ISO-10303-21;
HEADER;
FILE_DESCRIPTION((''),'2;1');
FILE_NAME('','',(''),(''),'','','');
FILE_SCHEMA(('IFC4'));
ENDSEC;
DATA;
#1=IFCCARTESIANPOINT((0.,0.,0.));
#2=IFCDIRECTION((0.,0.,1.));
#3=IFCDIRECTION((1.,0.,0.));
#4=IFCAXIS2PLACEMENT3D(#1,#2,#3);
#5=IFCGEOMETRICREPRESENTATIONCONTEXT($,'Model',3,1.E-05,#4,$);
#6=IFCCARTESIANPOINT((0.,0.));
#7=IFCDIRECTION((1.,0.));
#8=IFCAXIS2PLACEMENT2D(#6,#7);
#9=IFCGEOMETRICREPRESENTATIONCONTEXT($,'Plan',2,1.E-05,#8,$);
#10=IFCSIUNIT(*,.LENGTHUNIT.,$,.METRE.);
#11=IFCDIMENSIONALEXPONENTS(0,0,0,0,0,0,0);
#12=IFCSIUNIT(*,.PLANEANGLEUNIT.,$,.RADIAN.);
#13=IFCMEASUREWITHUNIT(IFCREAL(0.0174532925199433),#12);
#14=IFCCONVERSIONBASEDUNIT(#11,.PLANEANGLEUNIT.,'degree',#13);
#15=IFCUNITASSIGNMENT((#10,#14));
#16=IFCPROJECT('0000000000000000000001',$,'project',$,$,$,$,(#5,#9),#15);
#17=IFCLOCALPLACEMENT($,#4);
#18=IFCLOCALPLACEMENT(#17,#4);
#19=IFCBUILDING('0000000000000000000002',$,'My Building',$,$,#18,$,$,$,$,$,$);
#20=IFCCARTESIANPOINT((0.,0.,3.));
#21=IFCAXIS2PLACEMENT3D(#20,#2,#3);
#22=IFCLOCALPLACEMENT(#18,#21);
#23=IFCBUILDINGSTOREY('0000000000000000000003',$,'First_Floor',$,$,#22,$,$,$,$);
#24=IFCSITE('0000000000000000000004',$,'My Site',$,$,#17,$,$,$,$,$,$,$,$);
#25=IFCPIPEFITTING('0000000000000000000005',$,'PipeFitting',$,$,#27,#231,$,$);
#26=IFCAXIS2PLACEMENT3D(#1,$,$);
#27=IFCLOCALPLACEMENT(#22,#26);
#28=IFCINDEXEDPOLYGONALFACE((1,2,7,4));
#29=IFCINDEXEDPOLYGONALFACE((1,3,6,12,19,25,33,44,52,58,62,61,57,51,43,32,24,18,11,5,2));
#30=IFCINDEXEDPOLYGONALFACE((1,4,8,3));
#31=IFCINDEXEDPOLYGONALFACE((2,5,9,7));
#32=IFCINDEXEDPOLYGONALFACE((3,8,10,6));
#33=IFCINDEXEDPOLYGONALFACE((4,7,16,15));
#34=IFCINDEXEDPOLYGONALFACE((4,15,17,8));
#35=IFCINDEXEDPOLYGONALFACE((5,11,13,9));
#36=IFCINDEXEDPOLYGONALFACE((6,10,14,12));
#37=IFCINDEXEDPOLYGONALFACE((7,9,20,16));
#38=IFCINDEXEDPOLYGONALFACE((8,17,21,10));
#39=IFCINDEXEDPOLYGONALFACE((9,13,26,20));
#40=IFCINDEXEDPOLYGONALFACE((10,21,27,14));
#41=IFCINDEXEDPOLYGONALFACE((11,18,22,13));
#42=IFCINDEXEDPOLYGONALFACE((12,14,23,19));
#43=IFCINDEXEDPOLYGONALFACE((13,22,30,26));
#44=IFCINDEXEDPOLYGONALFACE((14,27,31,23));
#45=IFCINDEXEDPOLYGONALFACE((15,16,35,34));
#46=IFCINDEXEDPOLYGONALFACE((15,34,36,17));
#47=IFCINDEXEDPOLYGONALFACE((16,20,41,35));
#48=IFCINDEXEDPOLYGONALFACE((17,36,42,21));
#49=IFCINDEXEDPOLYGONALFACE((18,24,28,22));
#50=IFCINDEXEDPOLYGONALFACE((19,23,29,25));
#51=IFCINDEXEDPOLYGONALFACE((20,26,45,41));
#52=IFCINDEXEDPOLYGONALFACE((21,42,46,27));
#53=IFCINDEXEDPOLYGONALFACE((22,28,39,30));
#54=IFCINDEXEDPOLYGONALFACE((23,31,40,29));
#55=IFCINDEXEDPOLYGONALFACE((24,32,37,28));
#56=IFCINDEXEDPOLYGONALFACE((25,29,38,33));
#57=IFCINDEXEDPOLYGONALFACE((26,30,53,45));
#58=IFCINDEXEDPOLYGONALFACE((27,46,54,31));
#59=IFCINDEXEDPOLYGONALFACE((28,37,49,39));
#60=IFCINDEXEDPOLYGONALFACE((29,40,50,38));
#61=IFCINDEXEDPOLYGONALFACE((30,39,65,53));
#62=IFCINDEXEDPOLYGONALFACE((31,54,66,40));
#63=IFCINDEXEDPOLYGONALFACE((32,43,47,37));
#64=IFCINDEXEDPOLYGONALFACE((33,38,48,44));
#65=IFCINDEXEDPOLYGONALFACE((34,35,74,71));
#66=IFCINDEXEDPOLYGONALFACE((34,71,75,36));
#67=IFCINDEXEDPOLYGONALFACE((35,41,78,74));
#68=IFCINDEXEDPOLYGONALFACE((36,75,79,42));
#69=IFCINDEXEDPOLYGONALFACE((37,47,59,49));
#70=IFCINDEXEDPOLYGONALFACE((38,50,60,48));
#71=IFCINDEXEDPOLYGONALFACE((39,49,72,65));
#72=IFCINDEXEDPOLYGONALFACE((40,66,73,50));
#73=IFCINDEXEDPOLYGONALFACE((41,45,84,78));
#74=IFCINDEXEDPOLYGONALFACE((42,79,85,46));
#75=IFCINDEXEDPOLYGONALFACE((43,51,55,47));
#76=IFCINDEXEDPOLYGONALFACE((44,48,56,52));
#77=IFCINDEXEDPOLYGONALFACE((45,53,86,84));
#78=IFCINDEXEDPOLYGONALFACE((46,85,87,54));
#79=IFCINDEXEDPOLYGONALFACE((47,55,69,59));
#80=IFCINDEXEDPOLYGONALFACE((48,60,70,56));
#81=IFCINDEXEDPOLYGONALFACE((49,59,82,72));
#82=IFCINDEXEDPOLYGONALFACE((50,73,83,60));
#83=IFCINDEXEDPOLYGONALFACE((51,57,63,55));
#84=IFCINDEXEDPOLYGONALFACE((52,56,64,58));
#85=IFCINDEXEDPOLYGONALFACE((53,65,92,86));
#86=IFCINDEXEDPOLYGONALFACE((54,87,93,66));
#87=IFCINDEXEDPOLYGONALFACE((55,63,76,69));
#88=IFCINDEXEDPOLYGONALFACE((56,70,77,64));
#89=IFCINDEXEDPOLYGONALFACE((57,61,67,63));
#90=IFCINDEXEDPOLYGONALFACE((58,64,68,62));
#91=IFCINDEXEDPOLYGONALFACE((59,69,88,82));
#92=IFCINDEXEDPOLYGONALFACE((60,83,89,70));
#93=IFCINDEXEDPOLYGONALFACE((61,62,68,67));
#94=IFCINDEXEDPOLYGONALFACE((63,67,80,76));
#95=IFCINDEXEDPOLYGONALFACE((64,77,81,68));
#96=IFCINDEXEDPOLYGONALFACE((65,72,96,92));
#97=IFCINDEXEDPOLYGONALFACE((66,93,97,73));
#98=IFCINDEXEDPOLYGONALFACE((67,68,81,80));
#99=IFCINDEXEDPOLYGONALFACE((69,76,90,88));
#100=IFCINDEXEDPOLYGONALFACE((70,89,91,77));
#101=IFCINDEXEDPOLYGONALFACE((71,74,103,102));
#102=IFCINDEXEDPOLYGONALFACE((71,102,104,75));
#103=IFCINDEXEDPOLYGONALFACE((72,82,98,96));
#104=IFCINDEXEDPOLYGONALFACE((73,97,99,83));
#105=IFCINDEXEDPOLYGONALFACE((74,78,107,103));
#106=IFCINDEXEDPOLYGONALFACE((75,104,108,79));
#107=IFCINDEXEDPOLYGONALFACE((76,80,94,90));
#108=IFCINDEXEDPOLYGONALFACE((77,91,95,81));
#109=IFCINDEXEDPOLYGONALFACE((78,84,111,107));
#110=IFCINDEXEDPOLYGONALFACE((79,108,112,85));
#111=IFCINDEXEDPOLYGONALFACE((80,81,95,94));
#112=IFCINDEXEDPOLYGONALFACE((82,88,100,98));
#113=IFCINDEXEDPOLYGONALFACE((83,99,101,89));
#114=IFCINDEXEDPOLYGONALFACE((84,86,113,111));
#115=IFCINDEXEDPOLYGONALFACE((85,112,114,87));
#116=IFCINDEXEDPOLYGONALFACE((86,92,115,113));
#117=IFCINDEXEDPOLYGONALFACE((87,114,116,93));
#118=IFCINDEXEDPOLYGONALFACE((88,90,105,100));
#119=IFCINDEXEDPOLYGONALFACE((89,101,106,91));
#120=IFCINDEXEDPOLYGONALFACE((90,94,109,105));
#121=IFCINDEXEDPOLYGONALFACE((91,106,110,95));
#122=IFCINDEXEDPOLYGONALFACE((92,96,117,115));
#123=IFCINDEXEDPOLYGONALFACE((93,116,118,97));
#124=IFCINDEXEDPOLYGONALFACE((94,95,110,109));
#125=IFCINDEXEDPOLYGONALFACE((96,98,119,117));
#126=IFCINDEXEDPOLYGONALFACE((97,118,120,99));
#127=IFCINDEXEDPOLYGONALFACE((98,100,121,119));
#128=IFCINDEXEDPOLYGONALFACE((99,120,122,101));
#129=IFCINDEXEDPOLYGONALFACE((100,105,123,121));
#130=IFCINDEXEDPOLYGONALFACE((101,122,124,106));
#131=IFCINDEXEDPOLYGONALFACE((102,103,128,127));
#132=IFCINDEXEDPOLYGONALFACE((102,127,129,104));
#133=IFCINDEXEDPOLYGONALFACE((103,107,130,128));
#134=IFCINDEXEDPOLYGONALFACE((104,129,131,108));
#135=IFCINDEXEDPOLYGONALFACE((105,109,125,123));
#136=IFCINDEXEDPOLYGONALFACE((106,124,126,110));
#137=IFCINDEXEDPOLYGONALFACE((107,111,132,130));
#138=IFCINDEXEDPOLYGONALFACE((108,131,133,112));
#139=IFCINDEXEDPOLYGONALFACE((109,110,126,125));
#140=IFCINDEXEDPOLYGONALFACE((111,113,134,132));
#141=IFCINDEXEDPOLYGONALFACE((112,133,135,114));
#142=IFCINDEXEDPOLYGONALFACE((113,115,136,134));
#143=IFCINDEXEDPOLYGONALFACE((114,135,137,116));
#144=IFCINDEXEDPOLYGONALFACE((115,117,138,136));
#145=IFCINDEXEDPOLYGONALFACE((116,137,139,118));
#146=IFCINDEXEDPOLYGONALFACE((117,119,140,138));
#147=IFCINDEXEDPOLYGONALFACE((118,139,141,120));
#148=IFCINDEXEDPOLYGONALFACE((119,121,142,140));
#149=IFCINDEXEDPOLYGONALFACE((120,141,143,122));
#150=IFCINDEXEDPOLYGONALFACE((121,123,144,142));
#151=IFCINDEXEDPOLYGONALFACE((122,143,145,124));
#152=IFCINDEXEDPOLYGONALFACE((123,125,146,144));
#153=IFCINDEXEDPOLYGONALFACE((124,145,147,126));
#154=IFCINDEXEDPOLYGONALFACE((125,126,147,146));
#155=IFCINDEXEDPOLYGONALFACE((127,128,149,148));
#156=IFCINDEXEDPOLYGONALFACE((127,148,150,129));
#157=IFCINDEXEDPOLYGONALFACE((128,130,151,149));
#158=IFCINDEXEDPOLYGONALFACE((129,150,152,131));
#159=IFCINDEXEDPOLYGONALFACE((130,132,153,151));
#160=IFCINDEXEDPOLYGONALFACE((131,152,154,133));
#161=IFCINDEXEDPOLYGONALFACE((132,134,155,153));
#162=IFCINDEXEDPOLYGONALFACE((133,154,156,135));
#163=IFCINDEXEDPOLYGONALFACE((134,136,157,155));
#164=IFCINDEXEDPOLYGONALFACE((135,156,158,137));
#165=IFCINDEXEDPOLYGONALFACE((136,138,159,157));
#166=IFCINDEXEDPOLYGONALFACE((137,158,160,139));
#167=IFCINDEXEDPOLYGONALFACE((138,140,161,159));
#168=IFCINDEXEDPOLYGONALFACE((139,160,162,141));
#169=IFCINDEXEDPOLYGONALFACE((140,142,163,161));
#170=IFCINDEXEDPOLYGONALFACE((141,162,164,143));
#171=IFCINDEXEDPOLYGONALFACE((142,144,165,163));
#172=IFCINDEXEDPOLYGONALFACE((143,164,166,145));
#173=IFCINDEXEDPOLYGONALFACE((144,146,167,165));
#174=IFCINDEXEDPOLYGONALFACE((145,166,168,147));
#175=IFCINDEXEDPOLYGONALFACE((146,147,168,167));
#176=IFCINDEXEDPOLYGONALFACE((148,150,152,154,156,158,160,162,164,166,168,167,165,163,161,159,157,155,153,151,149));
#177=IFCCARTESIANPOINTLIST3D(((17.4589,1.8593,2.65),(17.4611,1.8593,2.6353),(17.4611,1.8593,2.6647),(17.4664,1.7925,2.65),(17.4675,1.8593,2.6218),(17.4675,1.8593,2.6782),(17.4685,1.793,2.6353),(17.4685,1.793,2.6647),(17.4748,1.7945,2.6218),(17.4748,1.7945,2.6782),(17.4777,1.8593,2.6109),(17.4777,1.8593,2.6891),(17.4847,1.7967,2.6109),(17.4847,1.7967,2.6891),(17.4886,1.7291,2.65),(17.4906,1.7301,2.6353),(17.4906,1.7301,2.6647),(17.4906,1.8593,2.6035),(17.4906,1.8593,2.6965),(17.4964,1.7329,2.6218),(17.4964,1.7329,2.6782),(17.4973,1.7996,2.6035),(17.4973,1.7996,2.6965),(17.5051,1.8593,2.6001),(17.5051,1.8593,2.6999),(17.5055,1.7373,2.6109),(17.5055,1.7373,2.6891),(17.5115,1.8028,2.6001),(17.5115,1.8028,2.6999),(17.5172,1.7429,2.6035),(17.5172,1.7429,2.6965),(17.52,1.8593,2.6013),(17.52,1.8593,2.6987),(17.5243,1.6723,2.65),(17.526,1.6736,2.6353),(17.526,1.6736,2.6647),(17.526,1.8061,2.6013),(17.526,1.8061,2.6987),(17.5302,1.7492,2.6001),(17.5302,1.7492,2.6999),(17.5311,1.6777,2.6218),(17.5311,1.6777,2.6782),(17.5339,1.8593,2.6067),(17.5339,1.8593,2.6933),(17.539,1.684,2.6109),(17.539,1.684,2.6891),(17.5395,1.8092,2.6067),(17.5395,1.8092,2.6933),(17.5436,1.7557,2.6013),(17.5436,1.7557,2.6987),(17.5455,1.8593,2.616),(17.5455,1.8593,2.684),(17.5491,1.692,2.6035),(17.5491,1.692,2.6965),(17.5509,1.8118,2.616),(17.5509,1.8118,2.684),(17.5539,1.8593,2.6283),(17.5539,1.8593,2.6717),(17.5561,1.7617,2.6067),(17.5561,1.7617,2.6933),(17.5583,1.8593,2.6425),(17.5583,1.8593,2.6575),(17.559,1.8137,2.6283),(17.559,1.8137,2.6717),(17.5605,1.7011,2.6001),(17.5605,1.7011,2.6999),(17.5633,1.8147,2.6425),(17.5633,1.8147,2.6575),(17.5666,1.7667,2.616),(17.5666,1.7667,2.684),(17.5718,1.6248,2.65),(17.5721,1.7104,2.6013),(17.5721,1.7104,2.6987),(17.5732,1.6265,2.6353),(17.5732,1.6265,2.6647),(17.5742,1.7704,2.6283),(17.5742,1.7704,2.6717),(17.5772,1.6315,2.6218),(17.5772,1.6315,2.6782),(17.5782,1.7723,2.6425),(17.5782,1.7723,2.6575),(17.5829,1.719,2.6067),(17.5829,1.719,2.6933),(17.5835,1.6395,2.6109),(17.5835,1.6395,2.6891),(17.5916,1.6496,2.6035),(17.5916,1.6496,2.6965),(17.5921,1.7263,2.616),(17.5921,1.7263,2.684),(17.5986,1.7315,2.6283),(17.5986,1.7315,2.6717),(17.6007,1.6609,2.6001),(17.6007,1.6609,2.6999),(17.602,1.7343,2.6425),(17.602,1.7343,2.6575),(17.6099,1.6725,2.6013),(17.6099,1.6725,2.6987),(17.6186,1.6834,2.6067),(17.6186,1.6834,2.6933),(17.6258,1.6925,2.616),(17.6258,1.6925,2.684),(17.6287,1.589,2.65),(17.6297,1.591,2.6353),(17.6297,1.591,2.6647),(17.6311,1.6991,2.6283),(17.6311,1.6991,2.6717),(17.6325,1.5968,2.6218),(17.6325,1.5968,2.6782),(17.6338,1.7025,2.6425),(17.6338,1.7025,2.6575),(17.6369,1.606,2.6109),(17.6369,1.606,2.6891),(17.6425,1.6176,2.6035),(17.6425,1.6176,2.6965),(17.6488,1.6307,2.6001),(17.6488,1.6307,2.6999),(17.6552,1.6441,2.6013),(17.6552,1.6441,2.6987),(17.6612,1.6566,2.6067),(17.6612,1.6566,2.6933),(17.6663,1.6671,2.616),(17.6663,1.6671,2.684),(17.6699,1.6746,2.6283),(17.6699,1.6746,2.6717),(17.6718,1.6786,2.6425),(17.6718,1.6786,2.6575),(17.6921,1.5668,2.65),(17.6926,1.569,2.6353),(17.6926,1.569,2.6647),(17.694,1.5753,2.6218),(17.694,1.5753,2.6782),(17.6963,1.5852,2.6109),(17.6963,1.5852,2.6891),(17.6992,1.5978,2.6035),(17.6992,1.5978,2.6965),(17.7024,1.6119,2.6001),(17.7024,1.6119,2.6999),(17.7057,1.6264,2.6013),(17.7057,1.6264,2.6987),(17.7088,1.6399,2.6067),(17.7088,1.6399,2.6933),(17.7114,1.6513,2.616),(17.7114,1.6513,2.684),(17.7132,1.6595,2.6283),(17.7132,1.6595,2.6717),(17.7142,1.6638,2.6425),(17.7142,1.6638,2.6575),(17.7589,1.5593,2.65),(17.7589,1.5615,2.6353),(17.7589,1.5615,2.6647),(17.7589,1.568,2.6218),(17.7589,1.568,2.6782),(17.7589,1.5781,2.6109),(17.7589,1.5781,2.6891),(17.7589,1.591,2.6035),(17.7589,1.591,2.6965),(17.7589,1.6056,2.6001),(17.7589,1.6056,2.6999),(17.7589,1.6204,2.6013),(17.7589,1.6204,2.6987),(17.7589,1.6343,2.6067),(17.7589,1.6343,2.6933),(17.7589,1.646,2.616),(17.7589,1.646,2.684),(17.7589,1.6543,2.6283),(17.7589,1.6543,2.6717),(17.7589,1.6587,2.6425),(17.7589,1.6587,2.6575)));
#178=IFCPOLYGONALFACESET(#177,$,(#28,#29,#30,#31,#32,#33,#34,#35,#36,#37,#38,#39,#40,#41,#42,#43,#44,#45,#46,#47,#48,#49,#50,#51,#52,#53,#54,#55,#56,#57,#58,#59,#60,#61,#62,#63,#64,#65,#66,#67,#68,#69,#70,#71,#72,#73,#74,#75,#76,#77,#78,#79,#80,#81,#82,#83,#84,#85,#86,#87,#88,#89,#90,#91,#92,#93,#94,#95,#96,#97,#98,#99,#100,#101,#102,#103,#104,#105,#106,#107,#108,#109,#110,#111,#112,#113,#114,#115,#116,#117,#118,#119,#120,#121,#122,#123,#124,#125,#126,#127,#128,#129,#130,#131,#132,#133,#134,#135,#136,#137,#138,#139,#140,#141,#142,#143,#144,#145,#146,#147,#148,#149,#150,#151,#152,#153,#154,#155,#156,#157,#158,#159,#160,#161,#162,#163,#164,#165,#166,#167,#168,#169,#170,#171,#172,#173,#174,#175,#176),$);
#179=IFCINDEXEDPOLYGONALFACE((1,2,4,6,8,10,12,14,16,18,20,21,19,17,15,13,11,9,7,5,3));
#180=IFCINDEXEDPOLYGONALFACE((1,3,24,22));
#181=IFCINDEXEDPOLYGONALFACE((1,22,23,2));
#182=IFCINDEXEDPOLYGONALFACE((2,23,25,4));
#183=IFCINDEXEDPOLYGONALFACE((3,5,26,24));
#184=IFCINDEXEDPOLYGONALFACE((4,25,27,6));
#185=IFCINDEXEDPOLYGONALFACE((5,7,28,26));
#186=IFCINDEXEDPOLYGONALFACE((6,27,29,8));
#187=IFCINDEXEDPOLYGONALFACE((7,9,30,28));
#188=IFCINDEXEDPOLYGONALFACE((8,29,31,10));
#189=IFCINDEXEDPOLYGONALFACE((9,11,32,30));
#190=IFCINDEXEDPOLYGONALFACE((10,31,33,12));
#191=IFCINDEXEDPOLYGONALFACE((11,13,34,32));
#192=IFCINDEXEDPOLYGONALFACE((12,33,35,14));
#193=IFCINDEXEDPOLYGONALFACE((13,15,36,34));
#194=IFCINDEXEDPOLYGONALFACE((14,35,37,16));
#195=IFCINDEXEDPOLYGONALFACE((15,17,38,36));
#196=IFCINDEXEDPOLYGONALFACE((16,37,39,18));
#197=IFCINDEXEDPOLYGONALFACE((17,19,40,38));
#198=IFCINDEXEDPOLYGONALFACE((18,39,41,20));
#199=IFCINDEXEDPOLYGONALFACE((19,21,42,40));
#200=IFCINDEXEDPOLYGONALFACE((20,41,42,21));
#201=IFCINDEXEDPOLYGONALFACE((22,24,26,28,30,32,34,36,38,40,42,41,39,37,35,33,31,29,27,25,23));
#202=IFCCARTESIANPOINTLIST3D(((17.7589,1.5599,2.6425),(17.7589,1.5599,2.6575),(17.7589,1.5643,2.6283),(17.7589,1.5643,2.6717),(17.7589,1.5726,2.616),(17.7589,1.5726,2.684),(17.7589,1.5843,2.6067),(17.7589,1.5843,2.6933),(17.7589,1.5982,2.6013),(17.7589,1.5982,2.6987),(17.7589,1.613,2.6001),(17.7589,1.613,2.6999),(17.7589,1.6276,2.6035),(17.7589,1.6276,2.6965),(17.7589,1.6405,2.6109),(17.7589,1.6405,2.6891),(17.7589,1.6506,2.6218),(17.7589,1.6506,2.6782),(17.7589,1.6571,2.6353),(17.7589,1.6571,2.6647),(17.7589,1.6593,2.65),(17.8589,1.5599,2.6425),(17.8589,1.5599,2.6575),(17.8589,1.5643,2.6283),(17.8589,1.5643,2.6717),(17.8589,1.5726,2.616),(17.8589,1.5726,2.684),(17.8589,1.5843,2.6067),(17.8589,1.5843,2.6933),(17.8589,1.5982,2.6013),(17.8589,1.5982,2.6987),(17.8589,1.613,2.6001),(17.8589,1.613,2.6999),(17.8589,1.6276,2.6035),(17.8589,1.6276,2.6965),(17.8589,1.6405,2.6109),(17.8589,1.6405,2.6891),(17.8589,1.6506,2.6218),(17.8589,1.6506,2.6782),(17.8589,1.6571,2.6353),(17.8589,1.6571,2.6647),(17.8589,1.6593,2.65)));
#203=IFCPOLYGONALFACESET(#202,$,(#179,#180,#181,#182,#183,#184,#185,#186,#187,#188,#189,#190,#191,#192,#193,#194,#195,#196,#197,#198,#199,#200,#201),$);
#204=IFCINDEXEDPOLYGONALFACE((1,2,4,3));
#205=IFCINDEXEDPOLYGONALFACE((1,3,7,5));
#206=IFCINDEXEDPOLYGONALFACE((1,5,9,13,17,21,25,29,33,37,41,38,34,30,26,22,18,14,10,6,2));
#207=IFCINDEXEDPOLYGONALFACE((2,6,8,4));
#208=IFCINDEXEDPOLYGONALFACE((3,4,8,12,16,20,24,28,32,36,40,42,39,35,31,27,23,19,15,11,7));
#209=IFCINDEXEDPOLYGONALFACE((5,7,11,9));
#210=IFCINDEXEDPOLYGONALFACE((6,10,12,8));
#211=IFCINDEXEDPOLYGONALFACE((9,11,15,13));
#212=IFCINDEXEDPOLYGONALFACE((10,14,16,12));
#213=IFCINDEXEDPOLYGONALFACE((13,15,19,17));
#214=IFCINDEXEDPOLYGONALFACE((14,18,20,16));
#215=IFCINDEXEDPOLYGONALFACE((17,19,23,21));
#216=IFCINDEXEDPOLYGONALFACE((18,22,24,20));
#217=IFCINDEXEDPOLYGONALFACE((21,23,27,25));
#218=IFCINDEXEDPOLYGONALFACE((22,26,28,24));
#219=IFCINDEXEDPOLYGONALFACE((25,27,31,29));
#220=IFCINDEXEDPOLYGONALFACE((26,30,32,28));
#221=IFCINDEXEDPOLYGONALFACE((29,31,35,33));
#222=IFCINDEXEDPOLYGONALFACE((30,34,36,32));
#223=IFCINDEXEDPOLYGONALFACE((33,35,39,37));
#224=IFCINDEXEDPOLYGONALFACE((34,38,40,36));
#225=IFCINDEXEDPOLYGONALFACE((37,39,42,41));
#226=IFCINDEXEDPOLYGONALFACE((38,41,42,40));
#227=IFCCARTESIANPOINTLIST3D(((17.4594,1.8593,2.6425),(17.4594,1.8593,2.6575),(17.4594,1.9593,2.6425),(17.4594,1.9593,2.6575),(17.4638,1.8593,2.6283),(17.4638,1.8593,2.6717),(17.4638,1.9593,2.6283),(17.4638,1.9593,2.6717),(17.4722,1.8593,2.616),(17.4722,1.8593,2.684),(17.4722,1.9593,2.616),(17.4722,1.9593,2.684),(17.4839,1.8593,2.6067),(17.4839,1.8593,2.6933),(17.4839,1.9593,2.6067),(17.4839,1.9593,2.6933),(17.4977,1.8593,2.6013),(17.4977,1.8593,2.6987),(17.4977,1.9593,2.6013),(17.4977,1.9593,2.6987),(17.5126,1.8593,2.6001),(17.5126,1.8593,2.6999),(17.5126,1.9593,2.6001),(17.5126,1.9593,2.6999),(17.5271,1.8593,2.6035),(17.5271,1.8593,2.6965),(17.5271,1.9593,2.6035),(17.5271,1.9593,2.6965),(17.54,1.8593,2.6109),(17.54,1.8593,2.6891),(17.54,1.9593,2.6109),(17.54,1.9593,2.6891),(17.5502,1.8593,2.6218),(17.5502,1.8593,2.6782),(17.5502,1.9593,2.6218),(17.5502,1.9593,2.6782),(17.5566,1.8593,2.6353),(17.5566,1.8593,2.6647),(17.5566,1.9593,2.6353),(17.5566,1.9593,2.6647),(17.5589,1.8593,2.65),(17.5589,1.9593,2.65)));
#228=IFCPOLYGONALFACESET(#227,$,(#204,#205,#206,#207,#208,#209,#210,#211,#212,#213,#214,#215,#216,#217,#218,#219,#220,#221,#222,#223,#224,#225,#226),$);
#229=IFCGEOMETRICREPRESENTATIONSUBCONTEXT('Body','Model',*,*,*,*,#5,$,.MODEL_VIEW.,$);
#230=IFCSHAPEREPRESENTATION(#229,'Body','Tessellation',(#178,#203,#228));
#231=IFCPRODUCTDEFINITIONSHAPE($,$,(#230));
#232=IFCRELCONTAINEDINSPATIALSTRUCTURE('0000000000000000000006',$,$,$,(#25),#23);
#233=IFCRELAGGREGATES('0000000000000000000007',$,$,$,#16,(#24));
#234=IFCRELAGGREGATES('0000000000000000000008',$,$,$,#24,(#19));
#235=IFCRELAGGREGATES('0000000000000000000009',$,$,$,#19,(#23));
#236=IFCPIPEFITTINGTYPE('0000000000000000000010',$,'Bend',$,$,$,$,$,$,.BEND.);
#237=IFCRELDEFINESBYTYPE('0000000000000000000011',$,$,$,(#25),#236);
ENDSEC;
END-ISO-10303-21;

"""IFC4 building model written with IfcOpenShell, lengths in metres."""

from ifc_helpers import new_model, entity, si_unit, converted_unit, frame, origin_with_axes, origin_2d_with_axis, place, context, subcontext, project, spatial, circle, extrude, source, transform, mapped, type_object, type_shapes, element, save


model = new_model("IFC4")

# Units and contexts
model_context = context("Model", 3, precision=1e-05, world=origin_with_axes())
plan_context = context("Plan", 2, precision=1e-05, world=origin_2d_with_axis())
body_context = subcontext(model_context, "Body", "Model", "MODEL_VIEW")
ifc_project = project(units=[si_unit("LENGTHUNIT", "METRE"), converted_unit("PLANEANGLEUNIT", "degree", entity("IfcReal", 0.0174532925199433), si_unit("PLANEANGLEUNIT", "RADIAN"), dimensions=[0, 0, 0, 0, 0, 0, 0])], contexts=[model_context, plan_context])

# Site, building, storey
site_placement = place(None, origin_with_axes())
site = spatial("IfcSite", under=ifc_project, at=site_placement, Name="My Site")
building_placement = place(site_placement, origin_with_axes())
building = spatial("IfcBuilding", under=site, at=building_placement, Name="My Building")
storey_placement = place(building_placement, frame((0.0, 0.0, 3.0), z_axis=(0.0, 0.0, 1.0), x_axis=(1.0, 0.0, 0.0)))
storey = spatial("IfcBuildingStorey", under=building, at=storey_placement, Name="First_Floor")

# Pipe fitting
pipe_fitting_type = type_object("IfcPipeFittingType", Name="Bend", PredefinedType="BEND")
shared_shape_1 = source(origin_with_axes(), body_context, "Body", "SolidModel", [
    entity("IfcSweptDiskSolid", entity("IfcIndexedPolyCurve", entity("IfcCartesianPointList3D", [[0.0, 0.0, -0.1], [0.0732, 0.0, -0.2768], [0.25, 0.0, -0.35]]), [entity("IfcArcIndex", [1, 2, 3])]), 0.05),
    extrude(circle(Radius=0.05), origin_with_axes(), (0.0, 0.0, -1.0), 0.1),
    extrude(circle(Radius=0.05), frame((0.25, 0.0, -0.35), z_axis=(1.0, 0.0, 0.0), x_axis=(0.0, 0.0, 1.0)), (0.0, 0.0, 1.0), 0.1),
])
type_shapes(pipe_fitting_type, [shared_shape_1])
for number, where, z_axis, x_axis, name in (
    (1, (17.8589, 1.6093, 2.65), (1.0, 0.0, 0.0), (0.0, 1.0, 0.0), "PipeFitting"),
):
    element("IfcPipeFitting", number, at=place(storey_placement, frame(where, z_axis=z_axis, x_axis=x_axis)), inside=storey, type_object=pipe_fitting_type, Name=name, context=body_context, shape_type="MappedRepresentation", body=[
        mapped(shared_shape_1, transform((0.0, 0.0, 0.0), x_axis=(1.0, 0.0, 0.0), y_axis=(0.0, 1.0, 0.0), z_axis=(0.0, 0.0, 1.0), scale=1.0)),
    ])

save(model, "model.ifc")
